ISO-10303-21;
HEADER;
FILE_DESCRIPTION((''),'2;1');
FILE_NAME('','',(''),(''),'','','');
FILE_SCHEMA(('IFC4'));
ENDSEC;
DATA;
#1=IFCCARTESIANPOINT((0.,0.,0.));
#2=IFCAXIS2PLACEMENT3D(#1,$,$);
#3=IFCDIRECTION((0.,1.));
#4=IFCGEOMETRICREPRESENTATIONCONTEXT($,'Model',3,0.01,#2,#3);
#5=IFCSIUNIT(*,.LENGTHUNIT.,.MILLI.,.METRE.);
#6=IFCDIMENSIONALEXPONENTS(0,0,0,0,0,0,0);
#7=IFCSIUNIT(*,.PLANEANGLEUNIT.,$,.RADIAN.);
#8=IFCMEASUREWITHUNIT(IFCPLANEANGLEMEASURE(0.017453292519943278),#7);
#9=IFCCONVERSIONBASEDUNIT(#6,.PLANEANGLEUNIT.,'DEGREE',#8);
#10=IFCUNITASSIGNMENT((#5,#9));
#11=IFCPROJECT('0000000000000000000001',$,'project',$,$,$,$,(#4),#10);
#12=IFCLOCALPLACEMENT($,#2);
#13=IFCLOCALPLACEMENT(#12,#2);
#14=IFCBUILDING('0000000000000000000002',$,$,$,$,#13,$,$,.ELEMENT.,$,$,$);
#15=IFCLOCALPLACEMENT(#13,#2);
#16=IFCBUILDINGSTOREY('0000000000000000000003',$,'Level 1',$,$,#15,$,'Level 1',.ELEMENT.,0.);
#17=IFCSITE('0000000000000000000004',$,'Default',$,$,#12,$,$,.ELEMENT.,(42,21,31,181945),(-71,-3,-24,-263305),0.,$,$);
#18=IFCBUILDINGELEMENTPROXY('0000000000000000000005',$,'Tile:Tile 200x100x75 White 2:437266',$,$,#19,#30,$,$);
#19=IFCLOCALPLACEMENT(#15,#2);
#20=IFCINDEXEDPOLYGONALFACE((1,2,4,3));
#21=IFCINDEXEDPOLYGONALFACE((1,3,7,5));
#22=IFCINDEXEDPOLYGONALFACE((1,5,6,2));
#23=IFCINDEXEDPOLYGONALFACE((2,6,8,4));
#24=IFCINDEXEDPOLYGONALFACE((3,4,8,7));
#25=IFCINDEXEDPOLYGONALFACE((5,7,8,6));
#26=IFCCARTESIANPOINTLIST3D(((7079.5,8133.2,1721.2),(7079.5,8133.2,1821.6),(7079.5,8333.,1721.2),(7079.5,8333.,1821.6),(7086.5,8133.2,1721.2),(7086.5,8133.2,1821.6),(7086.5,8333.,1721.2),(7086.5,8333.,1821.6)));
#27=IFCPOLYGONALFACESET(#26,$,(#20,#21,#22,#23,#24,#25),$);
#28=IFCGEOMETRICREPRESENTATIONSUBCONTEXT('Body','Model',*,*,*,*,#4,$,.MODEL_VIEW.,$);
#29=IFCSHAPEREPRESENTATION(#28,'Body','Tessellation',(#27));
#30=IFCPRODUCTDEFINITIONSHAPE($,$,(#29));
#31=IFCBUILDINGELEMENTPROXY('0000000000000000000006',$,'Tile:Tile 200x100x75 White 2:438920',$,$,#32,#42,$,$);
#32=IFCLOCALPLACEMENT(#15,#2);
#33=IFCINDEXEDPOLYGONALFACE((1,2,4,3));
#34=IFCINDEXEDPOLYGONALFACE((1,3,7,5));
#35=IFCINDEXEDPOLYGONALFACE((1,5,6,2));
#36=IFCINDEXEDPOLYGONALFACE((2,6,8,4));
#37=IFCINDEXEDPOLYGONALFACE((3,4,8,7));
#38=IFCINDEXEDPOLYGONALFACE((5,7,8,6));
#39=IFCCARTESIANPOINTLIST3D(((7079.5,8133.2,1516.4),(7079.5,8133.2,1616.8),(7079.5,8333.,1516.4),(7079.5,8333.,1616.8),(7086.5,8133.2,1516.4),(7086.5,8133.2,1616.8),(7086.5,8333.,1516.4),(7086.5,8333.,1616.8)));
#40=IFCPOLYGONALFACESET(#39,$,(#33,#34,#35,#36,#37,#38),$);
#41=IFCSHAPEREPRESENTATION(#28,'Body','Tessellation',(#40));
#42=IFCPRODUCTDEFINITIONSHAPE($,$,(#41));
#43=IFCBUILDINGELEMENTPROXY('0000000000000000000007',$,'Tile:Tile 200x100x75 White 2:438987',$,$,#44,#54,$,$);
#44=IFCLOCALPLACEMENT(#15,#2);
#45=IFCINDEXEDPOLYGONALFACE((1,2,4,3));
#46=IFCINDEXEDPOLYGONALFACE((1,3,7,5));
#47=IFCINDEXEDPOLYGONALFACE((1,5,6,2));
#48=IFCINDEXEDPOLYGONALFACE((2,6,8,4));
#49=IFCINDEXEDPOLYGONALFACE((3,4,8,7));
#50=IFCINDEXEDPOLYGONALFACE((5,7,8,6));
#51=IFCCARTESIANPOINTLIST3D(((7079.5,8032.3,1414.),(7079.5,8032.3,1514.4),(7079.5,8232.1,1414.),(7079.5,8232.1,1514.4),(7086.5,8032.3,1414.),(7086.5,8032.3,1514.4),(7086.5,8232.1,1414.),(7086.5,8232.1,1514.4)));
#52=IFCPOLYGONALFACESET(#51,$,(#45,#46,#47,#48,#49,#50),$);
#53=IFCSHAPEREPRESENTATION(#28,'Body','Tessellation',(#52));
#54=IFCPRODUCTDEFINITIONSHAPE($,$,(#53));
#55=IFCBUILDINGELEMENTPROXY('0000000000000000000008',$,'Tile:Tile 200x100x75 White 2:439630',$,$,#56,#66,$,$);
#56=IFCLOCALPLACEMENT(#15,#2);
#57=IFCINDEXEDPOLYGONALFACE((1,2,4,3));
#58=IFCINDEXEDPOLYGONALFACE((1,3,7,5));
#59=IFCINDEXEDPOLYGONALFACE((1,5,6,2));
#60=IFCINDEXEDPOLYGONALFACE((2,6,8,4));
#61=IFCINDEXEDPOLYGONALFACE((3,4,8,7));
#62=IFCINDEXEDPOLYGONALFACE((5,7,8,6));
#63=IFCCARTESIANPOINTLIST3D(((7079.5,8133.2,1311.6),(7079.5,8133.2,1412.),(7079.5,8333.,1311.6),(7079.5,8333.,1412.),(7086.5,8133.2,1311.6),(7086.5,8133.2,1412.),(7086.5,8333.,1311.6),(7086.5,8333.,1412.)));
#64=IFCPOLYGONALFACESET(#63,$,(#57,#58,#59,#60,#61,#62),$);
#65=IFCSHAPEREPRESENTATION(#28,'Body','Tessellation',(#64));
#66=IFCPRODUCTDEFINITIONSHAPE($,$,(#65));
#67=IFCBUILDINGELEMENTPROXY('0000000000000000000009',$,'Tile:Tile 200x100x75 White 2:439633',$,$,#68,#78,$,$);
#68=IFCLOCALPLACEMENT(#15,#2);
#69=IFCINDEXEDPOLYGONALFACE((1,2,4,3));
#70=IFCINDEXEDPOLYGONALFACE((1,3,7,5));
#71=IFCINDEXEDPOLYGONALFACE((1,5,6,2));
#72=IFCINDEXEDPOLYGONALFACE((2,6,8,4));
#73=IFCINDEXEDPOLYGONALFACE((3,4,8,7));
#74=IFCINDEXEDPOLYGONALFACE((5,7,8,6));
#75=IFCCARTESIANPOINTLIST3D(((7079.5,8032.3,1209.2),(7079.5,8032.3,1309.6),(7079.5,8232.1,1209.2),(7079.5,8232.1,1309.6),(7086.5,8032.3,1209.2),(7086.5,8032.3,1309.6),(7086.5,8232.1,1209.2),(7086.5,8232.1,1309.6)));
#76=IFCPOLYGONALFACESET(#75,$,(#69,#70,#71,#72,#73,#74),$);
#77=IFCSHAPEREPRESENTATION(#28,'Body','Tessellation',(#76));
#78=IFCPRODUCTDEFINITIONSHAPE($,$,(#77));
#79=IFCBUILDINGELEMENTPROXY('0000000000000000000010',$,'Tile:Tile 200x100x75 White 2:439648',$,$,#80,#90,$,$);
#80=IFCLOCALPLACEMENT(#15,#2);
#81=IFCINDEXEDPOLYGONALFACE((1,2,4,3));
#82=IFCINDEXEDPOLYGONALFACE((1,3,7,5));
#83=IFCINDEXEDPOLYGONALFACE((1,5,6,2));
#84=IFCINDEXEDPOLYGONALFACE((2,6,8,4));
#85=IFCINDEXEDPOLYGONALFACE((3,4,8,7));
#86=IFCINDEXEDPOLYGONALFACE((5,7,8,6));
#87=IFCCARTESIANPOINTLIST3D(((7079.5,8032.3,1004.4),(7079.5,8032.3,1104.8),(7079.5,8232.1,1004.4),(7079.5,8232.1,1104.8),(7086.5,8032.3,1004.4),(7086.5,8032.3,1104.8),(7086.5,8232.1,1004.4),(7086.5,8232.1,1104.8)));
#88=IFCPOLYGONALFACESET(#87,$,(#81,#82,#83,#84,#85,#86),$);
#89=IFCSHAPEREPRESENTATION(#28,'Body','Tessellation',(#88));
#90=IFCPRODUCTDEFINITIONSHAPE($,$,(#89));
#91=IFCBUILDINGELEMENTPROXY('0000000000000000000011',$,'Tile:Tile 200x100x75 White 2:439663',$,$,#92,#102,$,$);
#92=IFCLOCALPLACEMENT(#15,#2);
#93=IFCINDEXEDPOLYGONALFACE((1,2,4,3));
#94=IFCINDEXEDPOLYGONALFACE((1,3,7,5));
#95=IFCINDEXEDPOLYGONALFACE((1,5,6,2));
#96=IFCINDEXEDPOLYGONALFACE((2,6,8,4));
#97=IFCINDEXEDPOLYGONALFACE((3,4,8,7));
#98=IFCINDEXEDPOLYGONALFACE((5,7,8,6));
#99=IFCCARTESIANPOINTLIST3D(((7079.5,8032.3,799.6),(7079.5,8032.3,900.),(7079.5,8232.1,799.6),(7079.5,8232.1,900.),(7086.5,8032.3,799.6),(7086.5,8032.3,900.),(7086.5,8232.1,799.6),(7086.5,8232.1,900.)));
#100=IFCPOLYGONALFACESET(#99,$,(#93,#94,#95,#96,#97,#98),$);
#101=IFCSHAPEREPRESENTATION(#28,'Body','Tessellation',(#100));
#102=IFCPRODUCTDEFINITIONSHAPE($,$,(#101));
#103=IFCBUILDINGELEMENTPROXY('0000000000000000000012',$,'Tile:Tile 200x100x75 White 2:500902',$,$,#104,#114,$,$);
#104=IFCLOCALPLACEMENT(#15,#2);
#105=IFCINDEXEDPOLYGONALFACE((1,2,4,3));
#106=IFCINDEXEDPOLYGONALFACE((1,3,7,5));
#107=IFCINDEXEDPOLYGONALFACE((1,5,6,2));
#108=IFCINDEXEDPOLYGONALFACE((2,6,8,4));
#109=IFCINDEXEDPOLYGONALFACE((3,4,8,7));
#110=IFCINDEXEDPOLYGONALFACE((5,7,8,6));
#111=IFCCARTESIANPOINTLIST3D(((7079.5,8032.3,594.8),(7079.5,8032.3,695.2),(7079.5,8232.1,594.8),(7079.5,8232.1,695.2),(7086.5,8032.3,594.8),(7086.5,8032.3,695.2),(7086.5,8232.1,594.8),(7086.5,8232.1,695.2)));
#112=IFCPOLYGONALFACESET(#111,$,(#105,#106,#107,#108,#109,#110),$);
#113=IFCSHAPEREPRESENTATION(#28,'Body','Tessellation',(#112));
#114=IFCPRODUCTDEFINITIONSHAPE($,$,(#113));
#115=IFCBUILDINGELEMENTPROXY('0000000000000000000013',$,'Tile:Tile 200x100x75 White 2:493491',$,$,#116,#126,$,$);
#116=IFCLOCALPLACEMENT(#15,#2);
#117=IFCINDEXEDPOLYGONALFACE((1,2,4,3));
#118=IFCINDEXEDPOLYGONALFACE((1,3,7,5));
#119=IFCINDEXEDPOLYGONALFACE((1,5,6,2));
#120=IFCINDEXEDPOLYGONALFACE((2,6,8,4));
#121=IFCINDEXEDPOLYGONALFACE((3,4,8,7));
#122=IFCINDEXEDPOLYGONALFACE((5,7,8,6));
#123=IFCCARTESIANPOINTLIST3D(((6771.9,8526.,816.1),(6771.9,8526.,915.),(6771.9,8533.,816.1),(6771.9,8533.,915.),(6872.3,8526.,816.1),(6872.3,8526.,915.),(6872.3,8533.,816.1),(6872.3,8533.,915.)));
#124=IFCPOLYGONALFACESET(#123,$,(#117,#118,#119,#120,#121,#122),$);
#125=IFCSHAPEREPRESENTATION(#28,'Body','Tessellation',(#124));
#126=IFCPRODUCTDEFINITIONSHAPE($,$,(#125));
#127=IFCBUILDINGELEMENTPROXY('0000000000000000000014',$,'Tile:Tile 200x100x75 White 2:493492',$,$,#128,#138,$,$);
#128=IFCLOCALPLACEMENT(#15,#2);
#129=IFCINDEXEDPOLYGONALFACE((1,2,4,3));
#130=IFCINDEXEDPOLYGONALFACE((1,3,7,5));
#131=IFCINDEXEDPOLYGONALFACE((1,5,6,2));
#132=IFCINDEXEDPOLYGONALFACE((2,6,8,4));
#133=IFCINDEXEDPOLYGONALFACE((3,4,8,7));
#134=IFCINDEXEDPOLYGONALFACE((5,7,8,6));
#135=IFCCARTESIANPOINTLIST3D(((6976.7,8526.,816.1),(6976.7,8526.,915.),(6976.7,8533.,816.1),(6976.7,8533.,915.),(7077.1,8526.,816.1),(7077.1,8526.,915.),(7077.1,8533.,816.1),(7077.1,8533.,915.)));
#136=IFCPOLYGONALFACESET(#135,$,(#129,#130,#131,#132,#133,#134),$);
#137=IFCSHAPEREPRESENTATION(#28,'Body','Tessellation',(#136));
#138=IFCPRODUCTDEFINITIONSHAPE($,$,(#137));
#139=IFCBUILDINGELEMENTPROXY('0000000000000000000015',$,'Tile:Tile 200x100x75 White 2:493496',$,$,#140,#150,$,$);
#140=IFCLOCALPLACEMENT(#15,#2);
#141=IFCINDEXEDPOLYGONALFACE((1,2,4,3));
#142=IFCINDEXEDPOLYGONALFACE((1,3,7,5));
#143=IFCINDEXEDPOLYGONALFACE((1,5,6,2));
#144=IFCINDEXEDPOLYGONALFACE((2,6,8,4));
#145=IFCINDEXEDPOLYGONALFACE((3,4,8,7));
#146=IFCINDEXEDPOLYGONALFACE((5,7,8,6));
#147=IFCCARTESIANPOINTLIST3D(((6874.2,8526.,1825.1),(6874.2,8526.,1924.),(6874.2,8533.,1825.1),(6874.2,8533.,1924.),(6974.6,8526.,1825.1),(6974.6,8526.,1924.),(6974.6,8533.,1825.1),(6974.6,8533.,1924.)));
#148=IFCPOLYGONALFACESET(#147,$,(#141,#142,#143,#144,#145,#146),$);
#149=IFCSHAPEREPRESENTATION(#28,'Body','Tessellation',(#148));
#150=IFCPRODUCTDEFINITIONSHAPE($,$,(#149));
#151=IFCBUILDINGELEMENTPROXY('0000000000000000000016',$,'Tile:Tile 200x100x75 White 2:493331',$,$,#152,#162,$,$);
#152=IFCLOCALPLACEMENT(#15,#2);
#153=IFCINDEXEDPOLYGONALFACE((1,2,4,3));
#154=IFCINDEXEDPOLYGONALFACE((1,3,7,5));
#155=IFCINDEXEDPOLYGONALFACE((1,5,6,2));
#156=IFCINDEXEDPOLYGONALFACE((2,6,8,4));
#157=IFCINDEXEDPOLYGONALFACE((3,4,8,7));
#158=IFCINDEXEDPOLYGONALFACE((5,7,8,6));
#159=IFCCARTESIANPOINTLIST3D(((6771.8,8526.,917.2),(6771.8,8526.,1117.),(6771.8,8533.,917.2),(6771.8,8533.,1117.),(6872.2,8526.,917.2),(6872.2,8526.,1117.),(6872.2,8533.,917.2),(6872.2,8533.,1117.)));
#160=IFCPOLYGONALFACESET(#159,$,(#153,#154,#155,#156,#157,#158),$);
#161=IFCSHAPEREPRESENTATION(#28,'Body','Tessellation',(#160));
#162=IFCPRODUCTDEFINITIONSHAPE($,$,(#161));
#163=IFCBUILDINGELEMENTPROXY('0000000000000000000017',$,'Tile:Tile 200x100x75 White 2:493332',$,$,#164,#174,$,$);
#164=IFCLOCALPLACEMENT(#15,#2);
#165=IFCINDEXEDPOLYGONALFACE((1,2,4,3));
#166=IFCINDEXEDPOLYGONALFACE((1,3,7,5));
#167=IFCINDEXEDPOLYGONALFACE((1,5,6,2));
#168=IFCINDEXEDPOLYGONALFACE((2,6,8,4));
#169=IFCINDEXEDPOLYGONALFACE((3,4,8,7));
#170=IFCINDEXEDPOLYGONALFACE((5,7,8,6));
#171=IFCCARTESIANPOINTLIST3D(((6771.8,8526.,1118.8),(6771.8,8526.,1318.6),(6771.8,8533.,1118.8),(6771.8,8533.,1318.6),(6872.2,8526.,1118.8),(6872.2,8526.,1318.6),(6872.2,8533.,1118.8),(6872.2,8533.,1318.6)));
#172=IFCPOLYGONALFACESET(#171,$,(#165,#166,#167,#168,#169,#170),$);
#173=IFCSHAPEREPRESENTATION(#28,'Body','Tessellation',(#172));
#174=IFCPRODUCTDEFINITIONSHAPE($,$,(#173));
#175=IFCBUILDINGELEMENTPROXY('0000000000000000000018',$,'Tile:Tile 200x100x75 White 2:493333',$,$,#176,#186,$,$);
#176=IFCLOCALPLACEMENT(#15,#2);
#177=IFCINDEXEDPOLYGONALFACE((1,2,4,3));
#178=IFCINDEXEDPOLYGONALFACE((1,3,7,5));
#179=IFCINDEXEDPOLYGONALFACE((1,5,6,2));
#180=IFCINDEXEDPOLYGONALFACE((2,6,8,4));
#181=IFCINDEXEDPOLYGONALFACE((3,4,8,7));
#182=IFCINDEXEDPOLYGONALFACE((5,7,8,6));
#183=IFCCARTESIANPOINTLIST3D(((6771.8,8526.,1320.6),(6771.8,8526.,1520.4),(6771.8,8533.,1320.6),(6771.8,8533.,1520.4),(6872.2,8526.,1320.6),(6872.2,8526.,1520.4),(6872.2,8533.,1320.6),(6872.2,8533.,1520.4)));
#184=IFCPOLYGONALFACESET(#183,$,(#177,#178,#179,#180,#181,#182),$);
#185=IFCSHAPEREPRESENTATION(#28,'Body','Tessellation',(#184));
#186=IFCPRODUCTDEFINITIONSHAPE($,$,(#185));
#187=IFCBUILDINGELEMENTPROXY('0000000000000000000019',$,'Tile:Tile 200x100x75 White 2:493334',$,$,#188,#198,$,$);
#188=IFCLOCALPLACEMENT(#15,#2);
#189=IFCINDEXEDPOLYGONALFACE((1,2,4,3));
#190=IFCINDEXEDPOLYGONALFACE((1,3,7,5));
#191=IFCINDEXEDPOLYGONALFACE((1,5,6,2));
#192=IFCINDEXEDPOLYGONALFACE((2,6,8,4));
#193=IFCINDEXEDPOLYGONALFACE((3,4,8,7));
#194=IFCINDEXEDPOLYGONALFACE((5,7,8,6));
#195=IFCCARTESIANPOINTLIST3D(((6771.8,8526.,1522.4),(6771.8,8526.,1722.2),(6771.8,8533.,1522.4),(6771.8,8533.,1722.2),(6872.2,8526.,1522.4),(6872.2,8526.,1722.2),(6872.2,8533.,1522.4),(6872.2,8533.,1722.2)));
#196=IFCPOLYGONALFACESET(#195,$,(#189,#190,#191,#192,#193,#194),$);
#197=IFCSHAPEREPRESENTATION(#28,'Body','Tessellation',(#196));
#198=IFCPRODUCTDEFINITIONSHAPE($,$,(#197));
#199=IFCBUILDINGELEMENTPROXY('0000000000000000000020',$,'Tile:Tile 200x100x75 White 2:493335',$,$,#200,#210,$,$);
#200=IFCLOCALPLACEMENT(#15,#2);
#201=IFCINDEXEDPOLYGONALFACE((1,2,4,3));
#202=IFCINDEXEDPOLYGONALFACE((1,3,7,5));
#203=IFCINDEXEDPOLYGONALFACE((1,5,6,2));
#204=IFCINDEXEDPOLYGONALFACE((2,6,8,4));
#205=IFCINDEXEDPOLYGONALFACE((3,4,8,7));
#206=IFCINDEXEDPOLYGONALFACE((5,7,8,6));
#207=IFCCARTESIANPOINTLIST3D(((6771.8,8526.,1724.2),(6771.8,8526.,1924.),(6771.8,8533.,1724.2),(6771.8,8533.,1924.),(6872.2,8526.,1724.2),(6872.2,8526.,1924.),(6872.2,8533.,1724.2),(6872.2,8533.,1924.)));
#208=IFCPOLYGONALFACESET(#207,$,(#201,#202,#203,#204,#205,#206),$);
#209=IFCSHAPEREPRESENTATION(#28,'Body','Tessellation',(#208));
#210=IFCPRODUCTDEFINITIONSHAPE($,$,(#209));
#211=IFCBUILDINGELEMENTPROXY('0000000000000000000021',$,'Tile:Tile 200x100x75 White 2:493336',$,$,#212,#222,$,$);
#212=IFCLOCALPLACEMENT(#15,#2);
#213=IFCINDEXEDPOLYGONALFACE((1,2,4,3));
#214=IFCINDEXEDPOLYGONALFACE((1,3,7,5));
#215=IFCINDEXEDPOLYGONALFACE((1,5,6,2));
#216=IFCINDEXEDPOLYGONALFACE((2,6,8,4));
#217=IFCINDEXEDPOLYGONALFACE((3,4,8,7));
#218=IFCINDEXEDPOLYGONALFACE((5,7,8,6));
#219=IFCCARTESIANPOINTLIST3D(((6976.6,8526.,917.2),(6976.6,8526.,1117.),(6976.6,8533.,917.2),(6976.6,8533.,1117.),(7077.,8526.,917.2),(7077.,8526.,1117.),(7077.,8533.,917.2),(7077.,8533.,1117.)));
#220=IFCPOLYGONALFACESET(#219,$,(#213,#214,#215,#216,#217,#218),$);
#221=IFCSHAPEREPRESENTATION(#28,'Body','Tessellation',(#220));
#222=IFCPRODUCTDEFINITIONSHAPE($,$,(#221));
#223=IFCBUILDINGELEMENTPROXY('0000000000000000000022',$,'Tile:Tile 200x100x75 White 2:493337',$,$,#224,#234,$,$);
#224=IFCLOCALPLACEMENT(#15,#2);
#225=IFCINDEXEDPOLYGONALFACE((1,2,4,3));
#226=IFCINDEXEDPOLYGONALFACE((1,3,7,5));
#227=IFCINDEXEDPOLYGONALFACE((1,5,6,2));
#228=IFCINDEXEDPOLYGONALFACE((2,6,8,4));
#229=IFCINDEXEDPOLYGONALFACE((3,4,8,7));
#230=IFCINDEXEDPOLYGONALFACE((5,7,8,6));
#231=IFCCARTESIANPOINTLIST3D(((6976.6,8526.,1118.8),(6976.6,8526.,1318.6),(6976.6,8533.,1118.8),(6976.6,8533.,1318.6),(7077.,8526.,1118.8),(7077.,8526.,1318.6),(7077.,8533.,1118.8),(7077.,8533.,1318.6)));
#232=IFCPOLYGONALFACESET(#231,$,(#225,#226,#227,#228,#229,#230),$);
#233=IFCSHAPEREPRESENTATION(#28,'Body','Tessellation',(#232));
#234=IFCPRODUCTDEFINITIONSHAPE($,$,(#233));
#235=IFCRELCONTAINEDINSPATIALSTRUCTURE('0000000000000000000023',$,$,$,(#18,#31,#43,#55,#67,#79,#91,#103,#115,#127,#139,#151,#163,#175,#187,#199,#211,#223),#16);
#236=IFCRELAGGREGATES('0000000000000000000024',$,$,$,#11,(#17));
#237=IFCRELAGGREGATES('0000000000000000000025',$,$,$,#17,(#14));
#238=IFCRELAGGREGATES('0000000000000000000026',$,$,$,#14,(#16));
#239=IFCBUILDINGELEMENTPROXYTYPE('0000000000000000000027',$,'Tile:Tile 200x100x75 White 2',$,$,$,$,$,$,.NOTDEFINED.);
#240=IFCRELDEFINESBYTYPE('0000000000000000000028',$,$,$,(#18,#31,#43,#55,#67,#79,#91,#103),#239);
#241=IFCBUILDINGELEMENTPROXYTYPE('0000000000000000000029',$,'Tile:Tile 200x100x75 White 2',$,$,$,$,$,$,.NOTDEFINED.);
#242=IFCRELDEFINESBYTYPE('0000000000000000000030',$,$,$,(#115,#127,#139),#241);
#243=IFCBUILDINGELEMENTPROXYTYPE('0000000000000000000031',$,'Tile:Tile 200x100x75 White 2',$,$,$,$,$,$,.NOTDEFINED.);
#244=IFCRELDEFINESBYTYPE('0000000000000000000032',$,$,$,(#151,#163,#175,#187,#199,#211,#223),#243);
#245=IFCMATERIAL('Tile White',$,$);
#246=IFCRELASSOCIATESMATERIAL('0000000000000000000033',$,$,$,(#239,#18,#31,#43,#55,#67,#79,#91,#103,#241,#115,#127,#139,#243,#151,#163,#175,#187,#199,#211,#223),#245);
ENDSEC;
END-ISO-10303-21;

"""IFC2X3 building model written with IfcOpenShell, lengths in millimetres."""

from ifc_helpers import new_model, entity, si_unit, converted_unit, direction, frame, frame_2d, origin, origin_2d_with_axis, place, context, subcontext, project, spatial, rectangle, extrude, source, transform, mapped, material, type_object, type_shapes, element, save


model = new_model("IFC2X3")

# Units and contexts
model_context = context("Model", 3, precision=0.01, world=origin(), true_north=direction((0.0, 1.0)))
body_context = subcontext(model_context, "Body", "Model", "MODEL_VIEW")
ifc_project = project(units=[si_unit("LENGTHUNIT", "METRE", prefix="MILLI"), converted_unit("PLANEANGLEUNIT", "DEGREE", entity("IfcPlaneAngleMeasure", 0.017453292519943278), si_unit("PLANEANGLEUNIT", "RADIAN"), dimensions=[0, 0, 0, 0, 0, 0, 0])], contexts=[model_context])

# Site, building, storey
site_placement = place(None, origin())
site = spatial("IfcSite", under=ifc_project, at=site_placement, Name="Default", CompositionType="ELEMENT", RefLatitude=(42, 21, 31, 181945), RefLongitude=(-71, -3, -24, -263305), RefElevation=0.0)
building_placement = place(site_placement, origin())
building = spatial("IfcBuilding", under=site, at=building_placement, CompositionType="ELEMENT")
storey_placement = place(building_placement, origin())
storey = spatial("IfcBuildingStorey", under=building, at=storey_placement, Name="Level 1", LongName="Level 1", CompositionType="ELEMENT", Elevation=0.0)

# Building element proxies
ifc_material = material(Name="Tile White")
building_element_proxy_type_1 = type_object("IfcBuildingElementProxyType", Name="Tile:Tile 200x100x75 White 2", PredefinedType="NOTDEFINED", material=ifc_material)
shared_shape_1 = source(origin(), body_context, "Body", "SweptSolid", [
    extrude(rectangle(XDim=199.8, YDim=100.4, at=frame_2d((0.0, 0.0), x_axis=(1.0, 0.0))), frame((-50.2, -99.9, 0.0), z_axis=(0.0, 0.0, 1.0), x_axis=(0.0, -1.0, 0.0)), (0.0, 0.0, 1.0), 7.0),
])
type_shapes(building_element_proxy_type_1, [shared_shape_1])
for number, where, z_axis, x_axis, name in (
    (1, (7086.5, 8333.0, 1821.6), (-1.0, 0.0, 0.0), (0.0, 0.0, 1.0), "Tile:Tile 200x100x75 White 2:437266"),
    (2, (7086.5, 8333.0, 1616.8), (-1.0, 0.0, 0.0), (0.0, 0.0, 1.0), "Tile:Tile 200x100x75 White 2:438920"),
    (3, (7086.5, 8232.1, 1514.4), (-1.0, 0.0, 0.0), (0.0, 0.0, 1.0), "Tile:Tile 200x100x75 White 2:438987"),
    (4, (7086.5, 8333.0, 1412.0), (-1.0, 0.0, 0.0), (0.0, 0.0, 1.0), "Tile:Tile 200x100x75 White 2:439630"),
    (5, (7086.5, 8232.1, 1309.6), (-1.0, 0.0, 0.0), (0.0, 0.0, 1.0), "Tile:Tile 200x100x75 White 2:439633"),
    (6, (7086.5, 8232.1, 1104.8), (-1.0, 0.0, 0.0), (0.0, 0.0, 1.0), "Tile:Tile 200x100x75 White 2:439648"),
    (7, (7086.5, 8232.1, 900.0), (-1.0, 0.0, 0.0), (0.0, 0.0, 1.0), "Tile:Tile 200x100x75 White 2:439663"),
    (8, (7086.5, 8232.1, 695.2), (-1.0, 0.0, 0.0), (0.0, 0.0, 1.0), "Tile:Tile 200x100x75 White 2:500902"),
):
    element("IfcBuildingElementProxy", number, at=place(storey_placement, frame(where, z_axis=z_axis, x_axis=x_axis)), inside=storey, type_object=building_element_proxy_type_1, material=ifc_material, Name=name, context=body_context, shape_type="MappedRepresentation", body=[
        mapped(shared_shape_1, transform((0.0, 0.0, 0.0), scale=1.0)),
    ])
building_element_proxy_type_2 = type_object("IfcBuildingElementProxyType", Name="Tile:Tile 200x100x75 White 2", PredefinedType="NOTDEFINED", material=ifc_material)
shared_shape_2 = source(origin(), body_context, "Body", "SweptSolid", [
    extrude(rectangle(XDim=98.9, YDim=100.4, at=origin_2d_with_axis()), frame((-50.2, -49.5, 0.0), z_axis=(0.0, 0.0, 1.0), x_axis=(0.0, -1.0, 0.0)), (0.0, 0.0, 1.0), 7.0),
])
type_shapes(building_element_proxy_type_2, [shared_shape_2])
for number, where, z_axis, x_axis, name in (
    (9, (6872.3, 8533.0, 915.0), (0.0, -1.0, 0.0), (1.0, 0.0, 0.0), "Tile:Tile 200x100x75 White 2:493491"),
    (10, (7077.1, 8533.0, 915.0), (0.0, -1.0, 0.0), (1.0, 0.0, 0.0), "Tile:Tile 200x100x75 White 2:493492"),
    (11, (6974.6, 8533.0, 1924.0), (0.0, -1.0, 0.0), (1.0, 0.0, 0.0), "Tile:Tile 200x100x75 White 2:493496"),
):
    element("IfcBuildingElementProxy", number, at=place(storey_placement, frame(where, z_axis=z_axis, x_axis=x_axis)), inside=storey, type_object=building_element_proxy_type_2, material=ifc_material, Name=name, context=body_context, shape_type="MappedRepresentation", body=[
        mapped(shared_shape_2, transform((0.0, 0.0, 0.0), scale=1.0)),
    ])
building_element_proxy_type_3 = type_object("IfcBuildingElementProxyType", Name="Tile:Tile 200x100x75 White 2", PredefinedType="NOTDEFINED", material=ifc_material)
shared_shape_3 = source(origin(), body_context, "Body", "SweptSolid", [
    extrude(rectangle(XDim=199.8, YDim=100.4, at=frame_2d((0.0, 0.0), x_axis=(1.0, 0.0))), frame((-50.2, -99.9, 0.0), z_axis=(0.0, 0.0, 1.0), x_axis=(0.0, -1.0, 0.0)), (0.0, 0.0, 1.0), 7.0),
])
type_shapes(building_element_proxy_type_3, [shared_shape_3])
for number, where, z_axis, x_axis, name in (
    (12, (6872.2, 8533.0, 1117.0), (0.0, -1.0, 0.0), (1.0, 0.0, 0.0), "Tile:Tile 200x100x75 White 2:493331"),
    (13, (6872.2, 8533.0, 1318.6), (0.0, -1.0, 0.0), (1.0, 0.0, 0.0), "Tile:Tile 200x100x75 White 2:493332"),
    (14, (6872.2, 8533.0, 1520.4), (0.0, -1.0, 0.0), (1.0, 0.0, 0.0), "Tile:Tile 200x100x75 White 2:493333"),
    (15, (6872.2, 8533.0, 1722.2), (0.0, -1.0, 0.0), (1.0, 0.0, 0.0), "Tile:Tile 200x100x75 White 2:493334"),
    (16, (6872.2, 8533.0, 1924.0), (0.0, -1.0, 0.0), (1.0, 0.0, 0.0), "Tile:Tile 200x100x75 White 2:493335"),
    (17, (7077.0, 8533.0, 1117.0), (0.0, -1.0, 0.0), (1.0, 0.0, 0.0), "Tile:Tile 200x100x75 White 2:493336"),
    (18, (7077.0, 8533.0, 1318.6), (0.0, -1.0, 0.0), (1.0, 0.0, 0.0), "Tile:Tile 200x100x75 White 2:493337"),
):
    element("IfcBuildingElementProxy", number, at=place(storey_placement, frame(where, z_axis=z_axis, x_axis=x_axis)), inside=storey, type_object=building_element_proxy_type_3, material=ifc_material, Name=name, context=body_context, shape_type="MappedRepresentation", body=[
        mapped(shared_shape_3, transform((0.0, 0.0, 0.0), scale=1.0)),
    ])

save(model, "model.ifc")
